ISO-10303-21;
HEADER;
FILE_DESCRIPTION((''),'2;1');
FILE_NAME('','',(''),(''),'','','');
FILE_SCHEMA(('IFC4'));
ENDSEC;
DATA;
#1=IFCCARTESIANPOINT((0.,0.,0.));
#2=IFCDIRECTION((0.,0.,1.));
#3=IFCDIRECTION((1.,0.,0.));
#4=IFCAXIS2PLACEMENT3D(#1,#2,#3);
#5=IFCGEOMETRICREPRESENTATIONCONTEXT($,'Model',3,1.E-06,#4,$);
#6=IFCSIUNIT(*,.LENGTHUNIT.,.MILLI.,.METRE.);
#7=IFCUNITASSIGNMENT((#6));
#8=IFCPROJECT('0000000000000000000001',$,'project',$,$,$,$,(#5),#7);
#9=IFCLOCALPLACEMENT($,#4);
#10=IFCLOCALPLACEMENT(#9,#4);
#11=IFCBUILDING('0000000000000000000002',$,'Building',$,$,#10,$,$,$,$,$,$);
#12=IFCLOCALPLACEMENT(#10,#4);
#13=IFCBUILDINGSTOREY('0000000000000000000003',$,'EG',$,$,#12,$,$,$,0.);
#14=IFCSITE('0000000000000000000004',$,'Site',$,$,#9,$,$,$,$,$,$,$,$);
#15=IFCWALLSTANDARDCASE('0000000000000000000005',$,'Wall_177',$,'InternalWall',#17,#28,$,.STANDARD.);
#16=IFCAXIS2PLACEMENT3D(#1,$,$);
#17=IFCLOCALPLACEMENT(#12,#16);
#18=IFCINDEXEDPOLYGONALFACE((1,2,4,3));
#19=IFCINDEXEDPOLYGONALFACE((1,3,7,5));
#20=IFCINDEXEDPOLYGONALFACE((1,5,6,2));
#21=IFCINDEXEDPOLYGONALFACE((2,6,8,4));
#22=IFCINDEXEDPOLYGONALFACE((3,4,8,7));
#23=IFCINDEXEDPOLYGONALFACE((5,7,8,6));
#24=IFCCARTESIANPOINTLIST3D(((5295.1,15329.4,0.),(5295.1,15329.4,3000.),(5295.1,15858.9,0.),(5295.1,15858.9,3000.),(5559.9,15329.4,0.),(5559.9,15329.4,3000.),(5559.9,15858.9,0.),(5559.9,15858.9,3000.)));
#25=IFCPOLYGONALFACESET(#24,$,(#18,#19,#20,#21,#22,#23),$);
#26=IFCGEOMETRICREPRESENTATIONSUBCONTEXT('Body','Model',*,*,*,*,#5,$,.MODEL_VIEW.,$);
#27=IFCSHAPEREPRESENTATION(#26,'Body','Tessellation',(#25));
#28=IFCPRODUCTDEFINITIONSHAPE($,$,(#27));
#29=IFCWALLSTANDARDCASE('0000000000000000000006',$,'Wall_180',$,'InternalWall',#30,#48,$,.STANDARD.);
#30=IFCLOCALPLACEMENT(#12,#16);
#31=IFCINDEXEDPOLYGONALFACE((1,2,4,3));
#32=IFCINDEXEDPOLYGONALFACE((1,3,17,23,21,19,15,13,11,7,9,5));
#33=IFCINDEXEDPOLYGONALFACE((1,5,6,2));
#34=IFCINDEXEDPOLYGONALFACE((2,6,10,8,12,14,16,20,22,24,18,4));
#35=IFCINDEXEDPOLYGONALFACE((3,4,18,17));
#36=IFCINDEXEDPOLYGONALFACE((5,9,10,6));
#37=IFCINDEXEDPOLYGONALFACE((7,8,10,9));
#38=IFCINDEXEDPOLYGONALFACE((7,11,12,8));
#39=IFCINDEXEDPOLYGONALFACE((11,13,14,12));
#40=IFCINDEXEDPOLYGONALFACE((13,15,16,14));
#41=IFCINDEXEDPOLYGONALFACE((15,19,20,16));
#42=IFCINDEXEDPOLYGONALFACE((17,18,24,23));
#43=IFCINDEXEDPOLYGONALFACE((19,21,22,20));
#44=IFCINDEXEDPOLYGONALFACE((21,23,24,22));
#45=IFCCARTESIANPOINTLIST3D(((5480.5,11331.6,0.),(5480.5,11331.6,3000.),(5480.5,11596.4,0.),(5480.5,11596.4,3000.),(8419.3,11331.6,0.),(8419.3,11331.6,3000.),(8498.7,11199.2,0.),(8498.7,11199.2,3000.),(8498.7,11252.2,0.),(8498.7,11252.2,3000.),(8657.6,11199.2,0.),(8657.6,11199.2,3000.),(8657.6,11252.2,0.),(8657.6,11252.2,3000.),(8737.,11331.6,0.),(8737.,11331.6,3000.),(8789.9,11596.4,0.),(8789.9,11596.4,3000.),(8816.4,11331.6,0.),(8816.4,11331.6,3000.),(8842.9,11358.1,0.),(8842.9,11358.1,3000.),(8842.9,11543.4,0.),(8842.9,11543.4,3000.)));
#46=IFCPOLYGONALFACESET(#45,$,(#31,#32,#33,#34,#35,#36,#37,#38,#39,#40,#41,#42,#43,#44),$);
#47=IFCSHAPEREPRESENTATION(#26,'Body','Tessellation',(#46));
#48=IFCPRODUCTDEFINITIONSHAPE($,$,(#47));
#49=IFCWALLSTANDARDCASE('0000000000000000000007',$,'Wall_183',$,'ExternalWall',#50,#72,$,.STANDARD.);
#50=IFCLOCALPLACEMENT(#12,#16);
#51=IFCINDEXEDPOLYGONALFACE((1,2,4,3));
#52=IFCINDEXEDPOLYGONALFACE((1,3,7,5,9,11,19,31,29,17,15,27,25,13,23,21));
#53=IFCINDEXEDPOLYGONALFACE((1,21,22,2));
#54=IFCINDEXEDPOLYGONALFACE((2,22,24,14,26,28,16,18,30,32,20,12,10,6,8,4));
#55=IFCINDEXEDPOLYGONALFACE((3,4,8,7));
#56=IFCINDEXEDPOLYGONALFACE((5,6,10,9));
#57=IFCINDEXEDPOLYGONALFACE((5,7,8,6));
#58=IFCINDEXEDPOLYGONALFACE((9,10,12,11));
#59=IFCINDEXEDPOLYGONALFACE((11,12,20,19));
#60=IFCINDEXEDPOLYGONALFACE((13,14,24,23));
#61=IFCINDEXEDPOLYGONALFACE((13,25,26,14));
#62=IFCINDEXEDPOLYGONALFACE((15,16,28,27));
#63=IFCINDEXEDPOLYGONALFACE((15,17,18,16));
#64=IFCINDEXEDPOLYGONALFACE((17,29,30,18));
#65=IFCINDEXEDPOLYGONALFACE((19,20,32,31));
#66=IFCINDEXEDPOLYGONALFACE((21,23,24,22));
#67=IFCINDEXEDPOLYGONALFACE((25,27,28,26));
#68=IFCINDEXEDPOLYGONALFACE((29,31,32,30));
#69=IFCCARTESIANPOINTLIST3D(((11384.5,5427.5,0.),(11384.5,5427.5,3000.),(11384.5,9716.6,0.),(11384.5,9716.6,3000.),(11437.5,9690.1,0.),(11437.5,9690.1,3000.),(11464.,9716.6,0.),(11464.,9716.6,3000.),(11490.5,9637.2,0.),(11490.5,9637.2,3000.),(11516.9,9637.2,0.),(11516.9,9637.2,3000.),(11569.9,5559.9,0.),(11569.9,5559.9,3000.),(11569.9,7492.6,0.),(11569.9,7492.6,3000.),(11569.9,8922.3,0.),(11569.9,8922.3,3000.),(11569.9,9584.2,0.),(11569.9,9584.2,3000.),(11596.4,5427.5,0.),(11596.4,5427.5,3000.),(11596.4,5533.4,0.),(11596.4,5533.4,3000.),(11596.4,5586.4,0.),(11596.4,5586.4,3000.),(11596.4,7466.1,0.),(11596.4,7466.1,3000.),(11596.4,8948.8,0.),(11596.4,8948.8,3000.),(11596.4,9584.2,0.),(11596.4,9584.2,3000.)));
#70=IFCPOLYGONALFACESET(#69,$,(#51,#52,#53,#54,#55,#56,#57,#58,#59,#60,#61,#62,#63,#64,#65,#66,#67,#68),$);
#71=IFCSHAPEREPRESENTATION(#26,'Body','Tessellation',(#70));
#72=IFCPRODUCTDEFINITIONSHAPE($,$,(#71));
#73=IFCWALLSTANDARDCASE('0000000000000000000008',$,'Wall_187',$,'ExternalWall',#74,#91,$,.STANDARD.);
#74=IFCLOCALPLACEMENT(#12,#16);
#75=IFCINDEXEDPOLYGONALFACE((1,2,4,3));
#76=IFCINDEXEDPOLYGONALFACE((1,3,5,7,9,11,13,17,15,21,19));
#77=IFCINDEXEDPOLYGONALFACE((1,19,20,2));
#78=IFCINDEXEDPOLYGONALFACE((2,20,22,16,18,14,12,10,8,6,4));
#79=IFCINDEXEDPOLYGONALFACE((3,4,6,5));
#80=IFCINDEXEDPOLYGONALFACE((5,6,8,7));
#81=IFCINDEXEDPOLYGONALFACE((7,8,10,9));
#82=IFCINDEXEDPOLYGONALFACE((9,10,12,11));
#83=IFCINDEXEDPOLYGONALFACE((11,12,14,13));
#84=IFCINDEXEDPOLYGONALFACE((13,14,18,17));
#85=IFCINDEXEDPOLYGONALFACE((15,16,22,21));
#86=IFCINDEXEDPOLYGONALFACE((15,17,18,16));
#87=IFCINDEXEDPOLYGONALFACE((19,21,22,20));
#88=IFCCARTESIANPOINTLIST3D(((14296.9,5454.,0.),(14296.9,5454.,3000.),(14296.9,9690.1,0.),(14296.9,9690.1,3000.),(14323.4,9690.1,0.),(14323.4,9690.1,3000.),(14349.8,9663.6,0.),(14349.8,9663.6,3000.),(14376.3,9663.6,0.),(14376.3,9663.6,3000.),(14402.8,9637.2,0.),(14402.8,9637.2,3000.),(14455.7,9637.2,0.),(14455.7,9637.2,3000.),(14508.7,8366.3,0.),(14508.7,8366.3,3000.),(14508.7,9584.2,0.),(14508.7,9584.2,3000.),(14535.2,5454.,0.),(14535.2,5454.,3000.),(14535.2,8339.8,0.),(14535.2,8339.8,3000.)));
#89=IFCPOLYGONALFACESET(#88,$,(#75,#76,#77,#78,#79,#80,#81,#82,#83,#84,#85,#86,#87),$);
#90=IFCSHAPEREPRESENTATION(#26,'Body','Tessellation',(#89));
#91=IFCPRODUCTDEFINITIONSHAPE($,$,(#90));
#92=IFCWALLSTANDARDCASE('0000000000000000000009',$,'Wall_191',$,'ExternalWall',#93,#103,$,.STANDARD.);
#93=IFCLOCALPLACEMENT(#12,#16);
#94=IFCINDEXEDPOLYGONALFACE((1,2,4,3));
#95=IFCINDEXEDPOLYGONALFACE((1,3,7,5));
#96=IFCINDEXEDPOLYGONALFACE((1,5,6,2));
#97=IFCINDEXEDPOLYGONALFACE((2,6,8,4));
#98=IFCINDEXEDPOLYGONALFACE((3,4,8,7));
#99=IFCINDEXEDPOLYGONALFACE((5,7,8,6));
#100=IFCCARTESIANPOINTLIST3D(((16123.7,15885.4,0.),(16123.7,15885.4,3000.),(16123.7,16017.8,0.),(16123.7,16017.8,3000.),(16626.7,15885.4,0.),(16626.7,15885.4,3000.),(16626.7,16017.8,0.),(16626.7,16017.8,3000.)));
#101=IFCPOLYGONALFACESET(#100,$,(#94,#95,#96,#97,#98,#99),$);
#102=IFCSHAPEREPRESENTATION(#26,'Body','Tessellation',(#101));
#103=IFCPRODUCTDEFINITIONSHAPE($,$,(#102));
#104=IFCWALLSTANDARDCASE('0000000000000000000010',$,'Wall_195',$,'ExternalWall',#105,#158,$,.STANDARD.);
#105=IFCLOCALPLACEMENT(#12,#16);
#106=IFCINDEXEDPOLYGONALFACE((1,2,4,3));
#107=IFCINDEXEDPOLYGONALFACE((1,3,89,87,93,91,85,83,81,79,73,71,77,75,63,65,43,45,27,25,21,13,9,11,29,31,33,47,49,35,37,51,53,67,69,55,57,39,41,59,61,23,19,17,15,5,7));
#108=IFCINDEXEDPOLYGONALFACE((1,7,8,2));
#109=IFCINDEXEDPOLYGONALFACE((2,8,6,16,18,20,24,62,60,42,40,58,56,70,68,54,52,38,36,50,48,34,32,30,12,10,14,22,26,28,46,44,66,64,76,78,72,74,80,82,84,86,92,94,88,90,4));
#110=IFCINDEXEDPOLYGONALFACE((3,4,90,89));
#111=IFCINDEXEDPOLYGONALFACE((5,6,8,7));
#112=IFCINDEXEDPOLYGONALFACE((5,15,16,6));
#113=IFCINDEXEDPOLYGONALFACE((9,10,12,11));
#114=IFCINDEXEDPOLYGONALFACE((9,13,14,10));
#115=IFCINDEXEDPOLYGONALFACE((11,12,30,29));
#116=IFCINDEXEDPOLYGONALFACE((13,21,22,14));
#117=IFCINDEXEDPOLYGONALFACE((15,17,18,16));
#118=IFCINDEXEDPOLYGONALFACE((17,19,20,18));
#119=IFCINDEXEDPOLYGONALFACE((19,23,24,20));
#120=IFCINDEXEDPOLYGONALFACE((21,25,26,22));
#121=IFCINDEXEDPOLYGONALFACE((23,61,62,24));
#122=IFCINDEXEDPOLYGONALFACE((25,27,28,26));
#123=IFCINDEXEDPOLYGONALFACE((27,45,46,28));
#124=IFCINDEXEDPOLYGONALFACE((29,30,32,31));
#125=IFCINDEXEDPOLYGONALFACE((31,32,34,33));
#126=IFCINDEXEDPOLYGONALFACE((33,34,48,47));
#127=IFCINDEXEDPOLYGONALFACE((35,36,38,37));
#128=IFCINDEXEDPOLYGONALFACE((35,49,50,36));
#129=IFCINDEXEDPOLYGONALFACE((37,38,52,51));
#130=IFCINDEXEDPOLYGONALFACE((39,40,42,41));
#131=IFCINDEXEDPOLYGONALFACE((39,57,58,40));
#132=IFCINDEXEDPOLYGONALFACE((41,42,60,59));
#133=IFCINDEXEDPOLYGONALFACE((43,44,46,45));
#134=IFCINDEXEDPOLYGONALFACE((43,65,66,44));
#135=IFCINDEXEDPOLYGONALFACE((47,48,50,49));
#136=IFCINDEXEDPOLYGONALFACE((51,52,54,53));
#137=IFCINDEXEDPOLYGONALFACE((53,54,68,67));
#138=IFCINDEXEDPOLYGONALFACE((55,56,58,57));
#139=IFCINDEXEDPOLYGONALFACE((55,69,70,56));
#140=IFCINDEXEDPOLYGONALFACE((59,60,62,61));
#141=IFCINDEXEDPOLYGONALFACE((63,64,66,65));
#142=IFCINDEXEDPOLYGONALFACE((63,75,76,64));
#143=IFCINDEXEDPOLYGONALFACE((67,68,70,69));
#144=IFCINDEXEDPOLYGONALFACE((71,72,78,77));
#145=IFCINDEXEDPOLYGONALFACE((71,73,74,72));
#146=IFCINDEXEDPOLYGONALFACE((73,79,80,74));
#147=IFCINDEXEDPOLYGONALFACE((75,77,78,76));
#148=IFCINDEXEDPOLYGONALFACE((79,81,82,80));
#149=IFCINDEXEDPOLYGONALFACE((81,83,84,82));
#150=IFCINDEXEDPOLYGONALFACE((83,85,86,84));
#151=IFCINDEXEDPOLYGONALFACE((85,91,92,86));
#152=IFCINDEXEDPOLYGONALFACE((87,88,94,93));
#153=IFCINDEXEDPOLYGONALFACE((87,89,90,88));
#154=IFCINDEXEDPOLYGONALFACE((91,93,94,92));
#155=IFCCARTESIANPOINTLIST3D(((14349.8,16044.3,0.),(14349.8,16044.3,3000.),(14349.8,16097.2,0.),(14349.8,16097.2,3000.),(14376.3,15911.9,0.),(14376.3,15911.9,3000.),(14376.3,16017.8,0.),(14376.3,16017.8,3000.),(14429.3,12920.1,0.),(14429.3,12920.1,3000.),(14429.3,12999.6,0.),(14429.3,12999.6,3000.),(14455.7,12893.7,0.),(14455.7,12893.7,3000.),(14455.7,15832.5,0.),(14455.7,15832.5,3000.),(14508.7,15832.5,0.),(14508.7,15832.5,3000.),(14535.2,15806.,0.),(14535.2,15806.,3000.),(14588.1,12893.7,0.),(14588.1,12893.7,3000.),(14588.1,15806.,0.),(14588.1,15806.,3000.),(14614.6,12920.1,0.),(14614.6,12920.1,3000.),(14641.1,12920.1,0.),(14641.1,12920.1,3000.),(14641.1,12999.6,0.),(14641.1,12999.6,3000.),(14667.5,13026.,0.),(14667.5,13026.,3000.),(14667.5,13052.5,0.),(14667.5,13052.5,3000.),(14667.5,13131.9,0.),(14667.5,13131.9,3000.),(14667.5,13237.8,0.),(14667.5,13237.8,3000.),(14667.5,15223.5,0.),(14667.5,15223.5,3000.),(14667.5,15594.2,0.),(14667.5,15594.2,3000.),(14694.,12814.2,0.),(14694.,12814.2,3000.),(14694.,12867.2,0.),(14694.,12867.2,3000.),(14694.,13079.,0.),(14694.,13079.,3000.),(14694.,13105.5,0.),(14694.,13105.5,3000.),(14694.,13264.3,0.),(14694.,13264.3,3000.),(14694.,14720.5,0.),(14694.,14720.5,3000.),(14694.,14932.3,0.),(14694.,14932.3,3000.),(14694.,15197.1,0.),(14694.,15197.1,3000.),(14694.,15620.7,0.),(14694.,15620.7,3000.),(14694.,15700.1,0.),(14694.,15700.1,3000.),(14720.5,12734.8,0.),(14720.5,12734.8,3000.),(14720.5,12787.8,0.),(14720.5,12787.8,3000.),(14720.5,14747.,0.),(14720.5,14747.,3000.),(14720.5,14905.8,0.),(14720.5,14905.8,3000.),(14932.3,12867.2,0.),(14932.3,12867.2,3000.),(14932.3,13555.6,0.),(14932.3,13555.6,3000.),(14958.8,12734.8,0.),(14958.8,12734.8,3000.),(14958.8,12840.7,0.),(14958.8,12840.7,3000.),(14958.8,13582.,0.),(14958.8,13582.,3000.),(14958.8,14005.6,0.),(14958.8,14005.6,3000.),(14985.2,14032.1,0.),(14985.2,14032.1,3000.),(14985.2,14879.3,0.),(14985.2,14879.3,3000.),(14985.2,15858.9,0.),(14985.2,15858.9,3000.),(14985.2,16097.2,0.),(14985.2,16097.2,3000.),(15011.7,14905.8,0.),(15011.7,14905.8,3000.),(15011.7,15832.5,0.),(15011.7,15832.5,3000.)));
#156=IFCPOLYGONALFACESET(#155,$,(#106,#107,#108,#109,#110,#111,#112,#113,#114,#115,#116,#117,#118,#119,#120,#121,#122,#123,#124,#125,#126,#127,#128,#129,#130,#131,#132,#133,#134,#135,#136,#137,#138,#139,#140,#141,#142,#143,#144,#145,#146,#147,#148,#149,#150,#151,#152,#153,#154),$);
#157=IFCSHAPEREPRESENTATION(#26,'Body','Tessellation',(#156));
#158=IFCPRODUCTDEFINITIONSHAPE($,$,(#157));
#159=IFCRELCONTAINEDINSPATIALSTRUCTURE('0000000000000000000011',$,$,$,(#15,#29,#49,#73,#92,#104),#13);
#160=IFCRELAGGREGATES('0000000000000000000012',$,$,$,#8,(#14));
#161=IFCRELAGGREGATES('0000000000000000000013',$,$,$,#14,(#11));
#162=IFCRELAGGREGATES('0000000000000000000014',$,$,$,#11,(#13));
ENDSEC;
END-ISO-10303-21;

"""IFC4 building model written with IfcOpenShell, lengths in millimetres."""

from ifc_helpers import new_model, si_unit, frame, origin_with_axes, place, context, subcontext, project, spatial, polyline, outline, extrude, element, save


model = new_model("IFC4")

# Units and contexts
model_context = context("Model", 3, precision=1e-06, world=origin_with_axes())
body_context = subcontext(model_context, "Body", "Model", "MODEL_VIEW")
ifc_project = project(units=[si_unit("LENGTHUNIT", "METRE", prefix="MILLI")], contexts=[model_context])

# Site, building, storey
site_placement = place(None, origin_with_axes())
site = spatial("IfcSite", under=ifc_project, at=site_placement, Name="Site")
building_placement = place(site_placement, origin_with_axes())
building = spatial("IfcBuilding", under=site, at=building_placement, Name="Building")
storey_placement = place(building_placement, origin_with_axes())
storey = spatial("IfcBuildingStorey", under=building, at=storey_placement, Name="EG", Elevation=0.0)

# Walls
for number, where, z_axis, x_axis, name in (
    (1, (0.0, 0.0, 0.0), (0.0, 0.0, 1.0), (1.0, 0.0, 0.0), "Wall_177"),
):
    element("IfcWallStandardCase", number, at=place(storey_placement, frame(where, z_axis=z_axis, x_axis=x_axis)), inside=storey, Name=name, ObjectType="InternalWall", PredefinedType="STANDARD", context=body_context, shape_type="SweptSolid", body=[
        extrude(outline(polyline([(5295.1, 15329.4, 0.0), (5295.1, 15858.9, 0.0), (5559.9, 15858.9, 0.0), (5559.9, 15329.4, 0.0), (5295.1, 15329.4, 0.0)])), origin_with_axes(), (0.0, 0.0, 1.0), 3000.0),
    ])
for number, where, z_axis, x_axis, name in (
    (2, (0.0, 0.0, 0.0), (0.0, 0.0, 1.0), (1.0, 0.0, 0.0), "Wall_180"),
):
    element("IfcWallStandardCase", number, at=place(storey_placement, frame(where, z_axis=z_axis, x_axis=x_axis)), inside=storey, Name=name, ObjectType="InternalWall", PredefinedType="STANDARD", context=body_context, shape_type="SweptSolid", body=[
        extrude(outline(polyline([(8498.7, 11199.2, 0.0), (8498.7, 11252.2, 0.0), (8419.3, 11331.6, 0.0), (5480.5, 11331.6, 0.0), (5480.5, 11596.4, 0.0), (8789.9, 11596.4, 0.0), (8842.9, 11543.4, 0.0), (8842.9, 11358.1, 0.0), (8816.4, 11331.6, 0.0), (8737.0, 11331.6, 0.0), (8657.6, 11252.2, 0.0), (8657.6, 11199.2, 0.0), (8498.7, 11199.2, 0.0)])), origin_with_axes(), (0.0, 0.0, 1.0), 3000.0),
    ])
for number, where, z_axis, x_axis, name in (
    (3, (0.0, 0.0, 0.0), (0.0, 0.0, 1.0), (1.0, 0.0, 0.0), "Wall_183"),
):
    element("IfcWallStandardCase", number, at=place(storey_placement, frame(where, z_axis=z_axis, x_axis=x_axis)), inside=storey, Name=name, ObjectType="ExternalWall", PredefinedType="STANDARD", context=body_context, shape_type="SweptSolid", body=[
        extrude(outline(polyline([(11384.5, 5427.5, 0.0), (11384.5, 9716.6, 0.0), (11464.0, 9716.6, 0.0), (11437.5, 9690.1, 0.0), (11490.5, 9637.2, 0.0), (11516.9, 9637.2, 0.0), (11569.9, 9584.2, 0.0), (11596.4, 9584.2, 0.0), (11596.4, 8948.8, 0.0), (11569.9, 8922.3, 0.0), (11569.9, 7492.6, 0.0), (11596.4, 7466.1, 0.0), (11596.4, 5586.4, 0.0), (11569.9, 5559.9, 0.0), (11596.4, 5533.4, 0.0), (11596.4, 5427.5, 0.0), (11384.5, 5427.5, 0.0)])), origin_with_axes(), (0.0, 0.0, 1.0), 3000.0),
    ])
for number, where, z_axis, x_axis, name in (
    (4, (0.0, 0.0, 0.0), (0.0, 0.0, 1.0), (1.0, 0.0, 0.0), "Wall_187"),
):
    element("IfcWallStandardCase", number, at=place(storey_placement, frame(where, z_axis=z_axis, x_axis=x_axis)), inside=storey, Name=name, ObjectType="ExternalWall", PredefinedType="STANDARD", context=body_context, shape_type="SweptSolid", body=[
        extrude(outline(polyline([(14296.9, 5454.0, 0.0), (14296.9, 9690.1, 0.0), (14323.4, 9690.1, 0.0), (14349.8, 9663.6, 0.0), (14376.3, 9663.6, 0.0), (14402.8, 9637.2, 0.0), (14455.7, 9637.2, 0.0), (14508.7, 9584.2, 0.0), (14508.7, 8366.3, 0.0), (14535.2, 8339.8, 0.0), (14535.2, 5454.0, 0.0), (14296.9, 5454.0, 0.0)])), origin_with_axes(), (0.0, 0.0, 1.0), 3000.0),
    ])
for number, where, z_axis, x_axis, name in (
    (5, (0.0, 0.0, 0.0), (0.0, 0.0, 1.0), (1.0, 0.0, 0.0), "Wall_191"),
):
    element("IfcWallStandardCase", number, at=place(storey_placement, frame(where, z_axis=z_axis, x_axis=x_axis)), inside=storey, Name=name, ObjectType="ExternalWall", PredefinedType="STANDARD", context=body_context, shape_type="SweptSolid", body=[
        extrude(outline(polyline([(16123.7, 15885.4, 0.0), (16123.7, 16017.8, 0.0), (16626.7, 16017.8, 0.0), (16626.7, 15885.4, 0.0), (16123.7, 15885.4, 0.0)])), origin_with_axes(), (0.0, 0.0, 1.0), 3000.0),
    ])
wall_1_placement = place(storey_placement, origin_with_axes())
element("IfcWallStandardCase", 6, at=wall_1_placement, inside=storey, Name="Wall_195", ObjectType="ExternalWall", PredefinedType="STANDARD", context=body_context, shape_type="SweptSolid", body=[
    extrude(outline(polyline([(14720.5, 12734.8, 0.0), (14720.5, 12787.8, 0.0), (14694.0, 12814.2, 0.0), (14694.0, 12867.2, 0.0), (14641.1, 12920.1, 0.0), (14614.6, 12920.1, 0.0), (14588.1, 12893.7, 0.0), (14455.7, 12893.7, 0.0), (14429.3, 12920.1, 0.0), (14429.3, 12999.6, 0.0), (14641.1, 12999.6, 0.0), (14667.5, 13026.0, 0.0), (14667.5, 13052.5, 0.0), (14694.0, 13079.0, 0.0), (14694.0, 13105.5, 0.0), (14667.5, 13131.9, 0.0), (14667.5, 13237.8, 0.0), (14694.0, 13264.3, 0.0), (14694.0, 14720.5, 0.0), (14720.5, 14747.0, 0.0), (14720.5, 14905.8, 0.0), (14694.0, 14932.3, 0.0), (14694.0, 15197.1, 0.0), (14667.5, 15223.5, 0.0), (14667.5, 15594.2, 0.0), (14694.0, 15620.7, 0.0), (14694.0, 15700.1, 0.0), (14588.1, 15806.0, 0.0), (14535.2, 15806.0, 0.0), (14508.7, 15832.5, 0.0), (14455.7, 15832.5, 0.0), (14376.3, 15911.9, 0.0), (14376.3, 16017.8, 0.0), (14349.8, 16044.3, 0.0), (14349.8, 16097.2, 0.0), (14985.2, 16097.2, 0.0), (14985.2, 15858.9, 0.0), (15011.7, 15832.5, 0.0), (15011.7, 14905.8, 0.0), (14985.2, 14879.3, 0.0), (14985.2, 14032.1, 0.0), (14958.8, 14005.6, 0.0), (14958.8, 13582.0, 0.0), (14932.3, 13555.6, 0.0), (14932.3, 12867.2, 0.0), (14958.8, 12840.7, 0.0), (14958.8, 12734.8, 0.0), (14720.5, 12734.8, 0.0)])), origin_with_axes(), (0.0, 0.0, 1.0), 3000.0),
])

save(model, "model.ifc")
